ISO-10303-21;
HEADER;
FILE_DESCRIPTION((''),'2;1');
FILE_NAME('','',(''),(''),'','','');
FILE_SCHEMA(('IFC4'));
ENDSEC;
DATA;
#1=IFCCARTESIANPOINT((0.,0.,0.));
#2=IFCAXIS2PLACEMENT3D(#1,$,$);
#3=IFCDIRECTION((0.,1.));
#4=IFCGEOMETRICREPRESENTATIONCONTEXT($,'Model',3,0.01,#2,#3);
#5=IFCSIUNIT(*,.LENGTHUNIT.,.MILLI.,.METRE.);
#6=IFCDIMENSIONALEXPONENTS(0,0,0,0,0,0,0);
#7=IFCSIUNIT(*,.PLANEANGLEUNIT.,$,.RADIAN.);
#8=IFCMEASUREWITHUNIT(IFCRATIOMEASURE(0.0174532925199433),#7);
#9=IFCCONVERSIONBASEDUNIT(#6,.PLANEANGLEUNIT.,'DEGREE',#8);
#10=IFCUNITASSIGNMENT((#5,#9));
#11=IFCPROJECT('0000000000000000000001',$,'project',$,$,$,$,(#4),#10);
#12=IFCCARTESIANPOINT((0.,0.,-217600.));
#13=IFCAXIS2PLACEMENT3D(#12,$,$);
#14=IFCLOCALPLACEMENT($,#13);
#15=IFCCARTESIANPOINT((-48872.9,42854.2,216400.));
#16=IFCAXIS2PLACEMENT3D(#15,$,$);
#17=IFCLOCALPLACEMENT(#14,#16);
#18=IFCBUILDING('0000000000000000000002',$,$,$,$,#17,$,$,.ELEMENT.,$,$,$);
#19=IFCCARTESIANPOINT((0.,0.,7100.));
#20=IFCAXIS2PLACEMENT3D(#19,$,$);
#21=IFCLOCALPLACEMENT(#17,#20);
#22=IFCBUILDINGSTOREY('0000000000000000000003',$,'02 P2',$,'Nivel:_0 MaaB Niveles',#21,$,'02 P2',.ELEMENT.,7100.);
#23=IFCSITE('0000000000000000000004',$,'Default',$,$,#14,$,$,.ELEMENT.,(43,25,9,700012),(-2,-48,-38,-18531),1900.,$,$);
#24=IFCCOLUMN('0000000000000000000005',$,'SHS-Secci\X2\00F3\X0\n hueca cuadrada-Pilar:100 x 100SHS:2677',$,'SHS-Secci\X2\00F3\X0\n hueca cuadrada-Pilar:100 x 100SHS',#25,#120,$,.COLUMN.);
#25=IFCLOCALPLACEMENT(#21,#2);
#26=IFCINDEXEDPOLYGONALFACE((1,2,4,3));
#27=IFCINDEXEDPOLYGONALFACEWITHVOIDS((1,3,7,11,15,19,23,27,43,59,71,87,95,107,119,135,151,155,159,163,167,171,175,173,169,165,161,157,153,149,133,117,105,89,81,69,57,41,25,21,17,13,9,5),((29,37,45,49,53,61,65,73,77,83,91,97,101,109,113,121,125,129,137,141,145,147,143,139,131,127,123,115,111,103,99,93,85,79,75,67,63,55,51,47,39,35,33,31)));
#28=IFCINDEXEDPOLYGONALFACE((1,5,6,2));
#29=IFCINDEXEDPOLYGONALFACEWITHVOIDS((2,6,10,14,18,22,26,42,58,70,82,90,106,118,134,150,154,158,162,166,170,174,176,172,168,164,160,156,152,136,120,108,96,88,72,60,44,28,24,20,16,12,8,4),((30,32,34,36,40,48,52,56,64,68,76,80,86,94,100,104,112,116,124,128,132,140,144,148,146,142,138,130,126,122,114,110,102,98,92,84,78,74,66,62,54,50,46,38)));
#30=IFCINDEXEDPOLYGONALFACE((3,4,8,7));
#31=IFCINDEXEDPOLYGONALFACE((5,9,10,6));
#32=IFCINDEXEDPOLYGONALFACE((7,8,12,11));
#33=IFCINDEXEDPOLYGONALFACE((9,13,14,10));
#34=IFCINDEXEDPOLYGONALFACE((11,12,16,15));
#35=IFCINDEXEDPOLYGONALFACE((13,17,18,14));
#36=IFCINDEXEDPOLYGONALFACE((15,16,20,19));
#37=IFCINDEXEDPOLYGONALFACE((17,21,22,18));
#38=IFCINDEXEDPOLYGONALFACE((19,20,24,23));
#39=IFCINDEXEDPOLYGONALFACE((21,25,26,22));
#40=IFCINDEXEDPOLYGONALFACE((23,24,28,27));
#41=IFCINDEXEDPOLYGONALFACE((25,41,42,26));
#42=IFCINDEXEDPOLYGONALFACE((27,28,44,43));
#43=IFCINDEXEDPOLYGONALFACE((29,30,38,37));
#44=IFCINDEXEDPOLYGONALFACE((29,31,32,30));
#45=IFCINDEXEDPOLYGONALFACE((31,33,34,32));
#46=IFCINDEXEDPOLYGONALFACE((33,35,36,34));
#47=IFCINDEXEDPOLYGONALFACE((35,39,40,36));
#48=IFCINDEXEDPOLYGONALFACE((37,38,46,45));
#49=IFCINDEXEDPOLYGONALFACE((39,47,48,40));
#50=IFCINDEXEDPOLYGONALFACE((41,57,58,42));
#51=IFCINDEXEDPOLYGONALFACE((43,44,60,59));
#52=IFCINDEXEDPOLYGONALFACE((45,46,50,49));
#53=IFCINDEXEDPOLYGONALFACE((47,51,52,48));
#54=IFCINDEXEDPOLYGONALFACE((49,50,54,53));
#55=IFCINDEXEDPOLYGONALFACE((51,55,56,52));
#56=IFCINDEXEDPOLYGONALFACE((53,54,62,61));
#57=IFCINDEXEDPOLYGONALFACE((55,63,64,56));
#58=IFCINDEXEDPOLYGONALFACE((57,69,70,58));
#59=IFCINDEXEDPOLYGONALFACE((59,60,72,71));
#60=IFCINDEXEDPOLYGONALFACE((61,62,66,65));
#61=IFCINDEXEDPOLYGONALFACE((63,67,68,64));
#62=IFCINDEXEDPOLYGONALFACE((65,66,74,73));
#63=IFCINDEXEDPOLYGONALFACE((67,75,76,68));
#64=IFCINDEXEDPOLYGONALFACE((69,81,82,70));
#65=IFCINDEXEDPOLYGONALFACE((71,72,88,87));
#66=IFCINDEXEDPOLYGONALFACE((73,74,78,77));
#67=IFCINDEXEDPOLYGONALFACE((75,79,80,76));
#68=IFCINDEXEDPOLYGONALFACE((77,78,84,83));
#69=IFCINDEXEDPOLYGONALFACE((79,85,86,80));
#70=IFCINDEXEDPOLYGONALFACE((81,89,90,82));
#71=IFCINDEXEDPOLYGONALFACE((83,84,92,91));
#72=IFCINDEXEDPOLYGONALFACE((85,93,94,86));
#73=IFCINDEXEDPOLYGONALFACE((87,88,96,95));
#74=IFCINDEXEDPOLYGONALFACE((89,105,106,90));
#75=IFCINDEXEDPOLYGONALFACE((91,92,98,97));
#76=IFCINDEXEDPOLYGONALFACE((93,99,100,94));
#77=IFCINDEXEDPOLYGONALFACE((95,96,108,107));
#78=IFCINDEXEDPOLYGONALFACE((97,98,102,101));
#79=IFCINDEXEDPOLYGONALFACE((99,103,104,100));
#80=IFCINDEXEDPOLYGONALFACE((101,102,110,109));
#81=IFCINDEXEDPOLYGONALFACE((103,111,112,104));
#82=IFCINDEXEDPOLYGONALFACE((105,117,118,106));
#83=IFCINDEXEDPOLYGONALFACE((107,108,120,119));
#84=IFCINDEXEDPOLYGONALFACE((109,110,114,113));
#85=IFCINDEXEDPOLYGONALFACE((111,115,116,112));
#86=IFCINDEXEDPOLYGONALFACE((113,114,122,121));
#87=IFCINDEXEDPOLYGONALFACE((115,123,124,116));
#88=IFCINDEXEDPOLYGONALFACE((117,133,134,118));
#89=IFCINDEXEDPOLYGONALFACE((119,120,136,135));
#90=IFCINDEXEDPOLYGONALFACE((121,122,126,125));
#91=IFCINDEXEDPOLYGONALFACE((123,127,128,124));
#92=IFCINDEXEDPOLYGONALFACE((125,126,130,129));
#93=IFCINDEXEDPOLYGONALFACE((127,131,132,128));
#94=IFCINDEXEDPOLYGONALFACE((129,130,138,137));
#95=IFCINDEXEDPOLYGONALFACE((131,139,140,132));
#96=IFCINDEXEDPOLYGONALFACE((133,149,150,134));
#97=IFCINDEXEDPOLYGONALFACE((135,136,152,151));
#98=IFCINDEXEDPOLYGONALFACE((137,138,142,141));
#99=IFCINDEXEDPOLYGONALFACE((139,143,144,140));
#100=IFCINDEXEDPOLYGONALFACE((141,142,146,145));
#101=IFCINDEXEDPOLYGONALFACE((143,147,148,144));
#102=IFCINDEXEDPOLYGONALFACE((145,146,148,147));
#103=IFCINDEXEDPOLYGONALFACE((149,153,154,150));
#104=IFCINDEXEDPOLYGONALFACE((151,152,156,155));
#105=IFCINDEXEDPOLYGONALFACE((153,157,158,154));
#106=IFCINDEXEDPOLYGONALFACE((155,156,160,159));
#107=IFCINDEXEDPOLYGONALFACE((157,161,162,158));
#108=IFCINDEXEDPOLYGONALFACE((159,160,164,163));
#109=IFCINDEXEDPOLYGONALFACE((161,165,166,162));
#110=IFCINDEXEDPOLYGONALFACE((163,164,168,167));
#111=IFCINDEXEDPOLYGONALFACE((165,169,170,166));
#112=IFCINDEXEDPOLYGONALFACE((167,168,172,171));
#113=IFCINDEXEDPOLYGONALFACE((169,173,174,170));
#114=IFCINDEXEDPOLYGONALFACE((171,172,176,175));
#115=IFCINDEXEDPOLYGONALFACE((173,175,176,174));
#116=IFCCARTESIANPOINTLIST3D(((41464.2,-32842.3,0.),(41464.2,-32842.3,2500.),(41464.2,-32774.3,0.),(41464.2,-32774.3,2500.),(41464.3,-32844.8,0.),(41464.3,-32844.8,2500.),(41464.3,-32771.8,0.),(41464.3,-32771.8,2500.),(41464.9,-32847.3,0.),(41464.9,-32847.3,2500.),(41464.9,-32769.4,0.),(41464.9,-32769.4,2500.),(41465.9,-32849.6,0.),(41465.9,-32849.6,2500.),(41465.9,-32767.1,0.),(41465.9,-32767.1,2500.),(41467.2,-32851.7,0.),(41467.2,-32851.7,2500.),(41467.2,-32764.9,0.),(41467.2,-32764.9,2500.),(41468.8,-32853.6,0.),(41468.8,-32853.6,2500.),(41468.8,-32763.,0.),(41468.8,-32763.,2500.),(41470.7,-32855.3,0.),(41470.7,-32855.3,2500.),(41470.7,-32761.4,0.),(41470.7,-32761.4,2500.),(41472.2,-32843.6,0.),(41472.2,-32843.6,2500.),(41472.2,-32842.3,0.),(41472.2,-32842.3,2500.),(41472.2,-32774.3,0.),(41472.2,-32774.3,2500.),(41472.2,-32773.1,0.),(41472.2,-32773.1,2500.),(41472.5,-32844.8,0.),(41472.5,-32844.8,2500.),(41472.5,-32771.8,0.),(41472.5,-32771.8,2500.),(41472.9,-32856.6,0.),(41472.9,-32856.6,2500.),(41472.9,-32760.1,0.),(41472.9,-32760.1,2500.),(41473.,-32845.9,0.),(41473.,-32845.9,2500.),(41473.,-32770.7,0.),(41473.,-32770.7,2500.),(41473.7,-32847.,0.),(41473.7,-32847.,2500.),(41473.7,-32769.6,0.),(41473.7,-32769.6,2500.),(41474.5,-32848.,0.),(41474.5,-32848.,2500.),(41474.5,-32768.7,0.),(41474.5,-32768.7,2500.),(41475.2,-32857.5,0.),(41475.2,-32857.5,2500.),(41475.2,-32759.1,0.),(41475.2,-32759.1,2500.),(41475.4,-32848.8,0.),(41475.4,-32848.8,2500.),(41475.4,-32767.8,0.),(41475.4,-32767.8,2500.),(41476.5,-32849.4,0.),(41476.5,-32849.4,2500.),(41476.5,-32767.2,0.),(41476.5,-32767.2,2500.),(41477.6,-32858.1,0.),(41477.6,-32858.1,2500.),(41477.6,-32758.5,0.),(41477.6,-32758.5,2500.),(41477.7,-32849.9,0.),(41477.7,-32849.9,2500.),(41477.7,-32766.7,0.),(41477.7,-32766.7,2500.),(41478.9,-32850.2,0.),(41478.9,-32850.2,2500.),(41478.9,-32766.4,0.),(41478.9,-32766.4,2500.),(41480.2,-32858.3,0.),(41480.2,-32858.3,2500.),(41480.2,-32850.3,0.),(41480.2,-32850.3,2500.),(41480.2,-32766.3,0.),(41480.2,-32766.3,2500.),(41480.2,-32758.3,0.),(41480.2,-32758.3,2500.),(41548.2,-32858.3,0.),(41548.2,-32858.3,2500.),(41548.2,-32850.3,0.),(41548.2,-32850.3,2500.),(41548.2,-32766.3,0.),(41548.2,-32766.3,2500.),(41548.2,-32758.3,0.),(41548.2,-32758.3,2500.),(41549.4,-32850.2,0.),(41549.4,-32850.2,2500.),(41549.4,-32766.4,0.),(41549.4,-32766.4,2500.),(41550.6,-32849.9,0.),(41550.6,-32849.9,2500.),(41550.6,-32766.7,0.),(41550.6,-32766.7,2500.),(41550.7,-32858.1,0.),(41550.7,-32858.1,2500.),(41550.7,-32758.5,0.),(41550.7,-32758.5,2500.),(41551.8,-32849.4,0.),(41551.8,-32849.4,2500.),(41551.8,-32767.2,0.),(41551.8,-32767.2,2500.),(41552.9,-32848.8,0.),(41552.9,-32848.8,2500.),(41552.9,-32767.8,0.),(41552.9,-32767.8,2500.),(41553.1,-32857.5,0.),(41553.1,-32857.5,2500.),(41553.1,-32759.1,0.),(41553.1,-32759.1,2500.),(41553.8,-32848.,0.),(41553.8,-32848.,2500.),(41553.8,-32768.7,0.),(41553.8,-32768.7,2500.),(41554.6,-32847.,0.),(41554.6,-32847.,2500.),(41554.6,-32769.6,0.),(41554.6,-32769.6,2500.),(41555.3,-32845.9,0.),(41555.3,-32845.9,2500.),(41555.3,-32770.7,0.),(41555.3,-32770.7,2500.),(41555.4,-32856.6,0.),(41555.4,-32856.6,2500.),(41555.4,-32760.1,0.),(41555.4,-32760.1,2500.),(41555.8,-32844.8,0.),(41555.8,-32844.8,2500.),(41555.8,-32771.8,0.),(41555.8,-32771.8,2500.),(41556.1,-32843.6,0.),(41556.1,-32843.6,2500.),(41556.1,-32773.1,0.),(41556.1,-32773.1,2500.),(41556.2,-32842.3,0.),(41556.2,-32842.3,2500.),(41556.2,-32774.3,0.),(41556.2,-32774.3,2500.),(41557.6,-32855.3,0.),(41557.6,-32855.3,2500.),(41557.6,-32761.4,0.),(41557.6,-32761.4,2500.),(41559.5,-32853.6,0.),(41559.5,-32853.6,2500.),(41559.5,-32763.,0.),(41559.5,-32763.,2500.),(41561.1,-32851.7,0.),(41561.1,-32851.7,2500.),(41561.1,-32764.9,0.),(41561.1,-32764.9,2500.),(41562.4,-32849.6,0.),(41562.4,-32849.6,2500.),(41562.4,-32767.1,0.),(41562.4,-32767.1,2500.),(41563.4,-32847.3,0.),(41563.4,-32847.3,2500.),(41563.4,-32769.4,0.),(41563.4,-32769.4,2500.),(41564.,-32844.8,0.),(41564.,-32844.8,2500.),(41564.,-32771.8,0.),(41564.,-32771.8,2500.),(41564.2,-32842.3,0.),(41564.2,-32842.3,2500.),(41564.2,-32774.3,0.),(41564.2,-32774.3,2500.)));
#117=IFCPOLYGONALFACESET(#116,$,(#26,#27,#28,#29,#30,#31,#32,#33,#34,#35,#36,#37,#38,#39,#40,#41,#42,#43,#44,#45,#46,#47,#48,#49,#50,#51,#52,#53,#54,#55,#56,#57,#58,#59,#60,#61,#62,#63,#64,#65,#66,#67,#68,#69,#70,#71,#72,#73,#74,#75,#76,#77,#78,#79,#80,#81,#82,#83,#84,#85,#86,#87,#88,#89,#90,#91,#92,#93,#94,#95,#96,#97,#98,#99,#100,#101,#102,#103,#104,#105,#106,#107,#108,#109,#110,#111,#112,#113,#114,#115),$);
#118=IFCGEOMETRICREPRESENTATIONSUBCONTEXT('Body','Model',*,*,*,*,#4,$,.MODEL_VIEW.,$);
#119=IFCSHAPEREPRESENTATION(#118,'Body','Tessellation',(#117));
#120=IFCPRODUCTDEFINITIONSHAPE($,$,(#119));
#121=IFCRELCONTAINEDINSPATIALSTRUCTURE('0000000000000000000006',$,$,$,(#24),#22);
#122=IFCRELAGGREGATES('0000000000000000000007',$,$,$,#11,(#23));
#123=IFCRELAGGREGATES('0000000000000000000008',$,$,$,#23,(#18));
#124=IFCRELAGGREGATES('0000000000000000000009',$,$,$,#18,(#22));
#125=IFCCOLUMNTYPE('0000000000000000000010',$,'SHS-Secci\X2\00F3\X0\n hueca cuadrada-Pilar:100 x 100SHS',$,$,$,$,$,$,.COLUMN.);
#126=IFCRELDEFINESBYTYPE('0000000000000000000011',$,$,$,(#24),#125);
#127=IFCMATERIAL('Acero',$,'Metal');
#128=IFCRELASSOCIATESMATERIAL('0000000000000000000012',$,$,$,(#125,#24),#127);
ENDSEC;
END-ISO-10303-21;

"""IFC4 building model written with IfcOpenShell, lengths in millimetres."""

from ifc_helpers import new_model, entity, si_unit, converted_unit, direction, frame, origin, place, context, subcontext, project, spatial, indexed_curve, outline, extrude, source, transform, mapped, material, type_object, type_shapes, element, save


model = new_model("IFC4")

# Units and contexts
model_context = context("Model", 3, precision=0.01, world=origin(), true_north=direction((0.0, 1.0)))
body_context = subcontext(model_context, "Body", "Model", "MODEL_VIEW")
ifc_project = project(units=[si_unit("LENGTHUNIT", "METRE", prefix="MILLI"), converted_unit("PLANEANGLEUNIT", "DEGREE", entity("IfcRatioMeasure", 0.0174532925199433), si_unit("PLANEANGLEUNIT", "RADIAN"), dimensions=[0, 0, 0, 0, 0, 0, 0])], contexts=[model_context])

# Site, building, storey
site_placement = place(None, frame((0.0, 0.0, -217600.0)))
site = spatial("IfcSite", under=ifc_project, at=site_placement, Name="Default", CompositionType="ELEMENT", RefLatitude=(43, 25, 9, 700012), RefLongitude=(-2, -48, -38, -18531), RefElevation=1900.0)
building_placement = place(site_placement, frame((-48872.9, 42854.2, 216400.0)))
building = spatial("IfcBuilding", under=site, at=building_placement, CompositionType="ELEMENT")
storey_placement = place(building_placement, frame((0.0, 0.0, 7100.0)))
storey = spatial("IfcBuildingStorey", under=building, at=storey_placement, Name="02 P2", ObjectType="Nivel:_0 MaaB Niveles", LongName="02 P2", CompositionType="ELEMENT", Elevation=7100.0)

# Column
ifc_material_1 = material(Name="Acero", Category="Metal")
column_type_1 = type_object("IfcColumnType", Name="SHS-Sección hueca cuadrada-Pilar:100 x 100SHS", PredefinedType="COLUMN", material=ifc_material_1)
shared_shape_1 = source(origin(), body_context, "Body", "SweptSolid", [
    extrude(outline(indexed_curve([(-34.0, -50.0), (34.0, -50.0), (36.5, -49.8), (38.9, -49.2), (41.3, -48.3), (43.4, -46.9), (45.3, -45.3), (46.9, -43.4), (48.3, -41.3), (49.2, -38.9), (49.8, -36.5), (50.0, -34.0), (50.0, 34.0), (49.8, 36.5), (49.2, 38.9), (48.3, 41.3), (46.9, 43.4), (45.3, 45.3), (43.4, 46.9), (41.3, 48.3), (38.9, 49.2), (36.5, 49.8), (34.0, 50.0), (-34.0, 50.0), (-36.5, 49.8), (-38.9, 49.2), (-41.3, 48.3), (-43.4, 46.9), (-45.3, 45.3), (-46.9, 43.4), (-48.3, 41.3), (-49.2, 38.9), (-49.8, 36.5), (-50.0, 34.0), (-50.0, -34.0), (-49.8, -36.5), (-49.2, -38.9), (-48.3, -41.3), (-46.9, -43.4), (-45.3, -45.3), (-43.4, -46.9), (-41.3, -48.3), (-38.9, -49.2), (-36.5, -49.8), (-34.0, -50.0)], self_intersect=False), holes=[indexed_curve([(-42.0, 34.0), (-41.9, 35.3), (-41.6, 36.5), (-41.1, 37.6), (-40.5, 38.7), (-39.7, 39.7), (-38.7, 40.5), (-37.6, 41.1), (-36.5, 41.6), (-35.3, 41.9), (-34.0, 42.0), (34.0, 42.0), (35.3, 41.9), (36.5, 41.6), (37.6, 41.1), (38.7, 40.5), (39.7, 39.7), (40.5, 38.7), (41.1, 37.6), (41.6, 36.5), (41.9, 35.3), (42.0, 34.0), (42.0, -34.0), (41.9, -35.3), (41.6, -36.5), (41.1, -37.6), (40.5, -38.7), (39.7, -39.7), (38.7, -40.5), (37.6, -41.1), (36.5, -41.6), (35.3, -41.9), (34.0, -42.0), (-34.0, -42.0), (-35.3, -41.9), (-36.5, -41.6), (-37.6, -41.1), (-38.7, -40.5), (-39.7, -39.7), (-40.5, -38.7), (-41.1, -37.6), (-41.6, -36.5), (-41.9, -35.3), (-42.0, -34.0), (-42.0, 34.0)], self_intersect=False)]), frame((0.0, 0.0, 7100.0), z_axis=(0.0, 0.0, 1.0), x_axis=(0.0, 1.0, 0.0)), (0.0, 0.0, 1.0), 2500.0),
])
type_shapes(column_type_1, [shared_shape_1])
column_1_placement = place(storey_placement, frame((41514.2, -32808.3, -7100.0), z_axis=(0.0, 0.0, 1.0), x_axis=(0.0, -1.0, 0.0)))
element("IfcColumn", 1, at=column_1_placement, inside=storey, type_object=column_type_1, material=ifc_material_1, Name="SHS-Sección hueca cuadrada-Pilar:100 x 100SHS:2677", ObjectType="SHS-Sección hueca cuadrada-Pilar:100 x 100SHS", PredefinedType="COLUMN", context=body_context, shape_type="MappedRepresentation", body=[
    mapped(shared_shape_1, transform((0.0, 0.0, 0.0), scale=1.0)),
])

save(model, "model.ifc")
